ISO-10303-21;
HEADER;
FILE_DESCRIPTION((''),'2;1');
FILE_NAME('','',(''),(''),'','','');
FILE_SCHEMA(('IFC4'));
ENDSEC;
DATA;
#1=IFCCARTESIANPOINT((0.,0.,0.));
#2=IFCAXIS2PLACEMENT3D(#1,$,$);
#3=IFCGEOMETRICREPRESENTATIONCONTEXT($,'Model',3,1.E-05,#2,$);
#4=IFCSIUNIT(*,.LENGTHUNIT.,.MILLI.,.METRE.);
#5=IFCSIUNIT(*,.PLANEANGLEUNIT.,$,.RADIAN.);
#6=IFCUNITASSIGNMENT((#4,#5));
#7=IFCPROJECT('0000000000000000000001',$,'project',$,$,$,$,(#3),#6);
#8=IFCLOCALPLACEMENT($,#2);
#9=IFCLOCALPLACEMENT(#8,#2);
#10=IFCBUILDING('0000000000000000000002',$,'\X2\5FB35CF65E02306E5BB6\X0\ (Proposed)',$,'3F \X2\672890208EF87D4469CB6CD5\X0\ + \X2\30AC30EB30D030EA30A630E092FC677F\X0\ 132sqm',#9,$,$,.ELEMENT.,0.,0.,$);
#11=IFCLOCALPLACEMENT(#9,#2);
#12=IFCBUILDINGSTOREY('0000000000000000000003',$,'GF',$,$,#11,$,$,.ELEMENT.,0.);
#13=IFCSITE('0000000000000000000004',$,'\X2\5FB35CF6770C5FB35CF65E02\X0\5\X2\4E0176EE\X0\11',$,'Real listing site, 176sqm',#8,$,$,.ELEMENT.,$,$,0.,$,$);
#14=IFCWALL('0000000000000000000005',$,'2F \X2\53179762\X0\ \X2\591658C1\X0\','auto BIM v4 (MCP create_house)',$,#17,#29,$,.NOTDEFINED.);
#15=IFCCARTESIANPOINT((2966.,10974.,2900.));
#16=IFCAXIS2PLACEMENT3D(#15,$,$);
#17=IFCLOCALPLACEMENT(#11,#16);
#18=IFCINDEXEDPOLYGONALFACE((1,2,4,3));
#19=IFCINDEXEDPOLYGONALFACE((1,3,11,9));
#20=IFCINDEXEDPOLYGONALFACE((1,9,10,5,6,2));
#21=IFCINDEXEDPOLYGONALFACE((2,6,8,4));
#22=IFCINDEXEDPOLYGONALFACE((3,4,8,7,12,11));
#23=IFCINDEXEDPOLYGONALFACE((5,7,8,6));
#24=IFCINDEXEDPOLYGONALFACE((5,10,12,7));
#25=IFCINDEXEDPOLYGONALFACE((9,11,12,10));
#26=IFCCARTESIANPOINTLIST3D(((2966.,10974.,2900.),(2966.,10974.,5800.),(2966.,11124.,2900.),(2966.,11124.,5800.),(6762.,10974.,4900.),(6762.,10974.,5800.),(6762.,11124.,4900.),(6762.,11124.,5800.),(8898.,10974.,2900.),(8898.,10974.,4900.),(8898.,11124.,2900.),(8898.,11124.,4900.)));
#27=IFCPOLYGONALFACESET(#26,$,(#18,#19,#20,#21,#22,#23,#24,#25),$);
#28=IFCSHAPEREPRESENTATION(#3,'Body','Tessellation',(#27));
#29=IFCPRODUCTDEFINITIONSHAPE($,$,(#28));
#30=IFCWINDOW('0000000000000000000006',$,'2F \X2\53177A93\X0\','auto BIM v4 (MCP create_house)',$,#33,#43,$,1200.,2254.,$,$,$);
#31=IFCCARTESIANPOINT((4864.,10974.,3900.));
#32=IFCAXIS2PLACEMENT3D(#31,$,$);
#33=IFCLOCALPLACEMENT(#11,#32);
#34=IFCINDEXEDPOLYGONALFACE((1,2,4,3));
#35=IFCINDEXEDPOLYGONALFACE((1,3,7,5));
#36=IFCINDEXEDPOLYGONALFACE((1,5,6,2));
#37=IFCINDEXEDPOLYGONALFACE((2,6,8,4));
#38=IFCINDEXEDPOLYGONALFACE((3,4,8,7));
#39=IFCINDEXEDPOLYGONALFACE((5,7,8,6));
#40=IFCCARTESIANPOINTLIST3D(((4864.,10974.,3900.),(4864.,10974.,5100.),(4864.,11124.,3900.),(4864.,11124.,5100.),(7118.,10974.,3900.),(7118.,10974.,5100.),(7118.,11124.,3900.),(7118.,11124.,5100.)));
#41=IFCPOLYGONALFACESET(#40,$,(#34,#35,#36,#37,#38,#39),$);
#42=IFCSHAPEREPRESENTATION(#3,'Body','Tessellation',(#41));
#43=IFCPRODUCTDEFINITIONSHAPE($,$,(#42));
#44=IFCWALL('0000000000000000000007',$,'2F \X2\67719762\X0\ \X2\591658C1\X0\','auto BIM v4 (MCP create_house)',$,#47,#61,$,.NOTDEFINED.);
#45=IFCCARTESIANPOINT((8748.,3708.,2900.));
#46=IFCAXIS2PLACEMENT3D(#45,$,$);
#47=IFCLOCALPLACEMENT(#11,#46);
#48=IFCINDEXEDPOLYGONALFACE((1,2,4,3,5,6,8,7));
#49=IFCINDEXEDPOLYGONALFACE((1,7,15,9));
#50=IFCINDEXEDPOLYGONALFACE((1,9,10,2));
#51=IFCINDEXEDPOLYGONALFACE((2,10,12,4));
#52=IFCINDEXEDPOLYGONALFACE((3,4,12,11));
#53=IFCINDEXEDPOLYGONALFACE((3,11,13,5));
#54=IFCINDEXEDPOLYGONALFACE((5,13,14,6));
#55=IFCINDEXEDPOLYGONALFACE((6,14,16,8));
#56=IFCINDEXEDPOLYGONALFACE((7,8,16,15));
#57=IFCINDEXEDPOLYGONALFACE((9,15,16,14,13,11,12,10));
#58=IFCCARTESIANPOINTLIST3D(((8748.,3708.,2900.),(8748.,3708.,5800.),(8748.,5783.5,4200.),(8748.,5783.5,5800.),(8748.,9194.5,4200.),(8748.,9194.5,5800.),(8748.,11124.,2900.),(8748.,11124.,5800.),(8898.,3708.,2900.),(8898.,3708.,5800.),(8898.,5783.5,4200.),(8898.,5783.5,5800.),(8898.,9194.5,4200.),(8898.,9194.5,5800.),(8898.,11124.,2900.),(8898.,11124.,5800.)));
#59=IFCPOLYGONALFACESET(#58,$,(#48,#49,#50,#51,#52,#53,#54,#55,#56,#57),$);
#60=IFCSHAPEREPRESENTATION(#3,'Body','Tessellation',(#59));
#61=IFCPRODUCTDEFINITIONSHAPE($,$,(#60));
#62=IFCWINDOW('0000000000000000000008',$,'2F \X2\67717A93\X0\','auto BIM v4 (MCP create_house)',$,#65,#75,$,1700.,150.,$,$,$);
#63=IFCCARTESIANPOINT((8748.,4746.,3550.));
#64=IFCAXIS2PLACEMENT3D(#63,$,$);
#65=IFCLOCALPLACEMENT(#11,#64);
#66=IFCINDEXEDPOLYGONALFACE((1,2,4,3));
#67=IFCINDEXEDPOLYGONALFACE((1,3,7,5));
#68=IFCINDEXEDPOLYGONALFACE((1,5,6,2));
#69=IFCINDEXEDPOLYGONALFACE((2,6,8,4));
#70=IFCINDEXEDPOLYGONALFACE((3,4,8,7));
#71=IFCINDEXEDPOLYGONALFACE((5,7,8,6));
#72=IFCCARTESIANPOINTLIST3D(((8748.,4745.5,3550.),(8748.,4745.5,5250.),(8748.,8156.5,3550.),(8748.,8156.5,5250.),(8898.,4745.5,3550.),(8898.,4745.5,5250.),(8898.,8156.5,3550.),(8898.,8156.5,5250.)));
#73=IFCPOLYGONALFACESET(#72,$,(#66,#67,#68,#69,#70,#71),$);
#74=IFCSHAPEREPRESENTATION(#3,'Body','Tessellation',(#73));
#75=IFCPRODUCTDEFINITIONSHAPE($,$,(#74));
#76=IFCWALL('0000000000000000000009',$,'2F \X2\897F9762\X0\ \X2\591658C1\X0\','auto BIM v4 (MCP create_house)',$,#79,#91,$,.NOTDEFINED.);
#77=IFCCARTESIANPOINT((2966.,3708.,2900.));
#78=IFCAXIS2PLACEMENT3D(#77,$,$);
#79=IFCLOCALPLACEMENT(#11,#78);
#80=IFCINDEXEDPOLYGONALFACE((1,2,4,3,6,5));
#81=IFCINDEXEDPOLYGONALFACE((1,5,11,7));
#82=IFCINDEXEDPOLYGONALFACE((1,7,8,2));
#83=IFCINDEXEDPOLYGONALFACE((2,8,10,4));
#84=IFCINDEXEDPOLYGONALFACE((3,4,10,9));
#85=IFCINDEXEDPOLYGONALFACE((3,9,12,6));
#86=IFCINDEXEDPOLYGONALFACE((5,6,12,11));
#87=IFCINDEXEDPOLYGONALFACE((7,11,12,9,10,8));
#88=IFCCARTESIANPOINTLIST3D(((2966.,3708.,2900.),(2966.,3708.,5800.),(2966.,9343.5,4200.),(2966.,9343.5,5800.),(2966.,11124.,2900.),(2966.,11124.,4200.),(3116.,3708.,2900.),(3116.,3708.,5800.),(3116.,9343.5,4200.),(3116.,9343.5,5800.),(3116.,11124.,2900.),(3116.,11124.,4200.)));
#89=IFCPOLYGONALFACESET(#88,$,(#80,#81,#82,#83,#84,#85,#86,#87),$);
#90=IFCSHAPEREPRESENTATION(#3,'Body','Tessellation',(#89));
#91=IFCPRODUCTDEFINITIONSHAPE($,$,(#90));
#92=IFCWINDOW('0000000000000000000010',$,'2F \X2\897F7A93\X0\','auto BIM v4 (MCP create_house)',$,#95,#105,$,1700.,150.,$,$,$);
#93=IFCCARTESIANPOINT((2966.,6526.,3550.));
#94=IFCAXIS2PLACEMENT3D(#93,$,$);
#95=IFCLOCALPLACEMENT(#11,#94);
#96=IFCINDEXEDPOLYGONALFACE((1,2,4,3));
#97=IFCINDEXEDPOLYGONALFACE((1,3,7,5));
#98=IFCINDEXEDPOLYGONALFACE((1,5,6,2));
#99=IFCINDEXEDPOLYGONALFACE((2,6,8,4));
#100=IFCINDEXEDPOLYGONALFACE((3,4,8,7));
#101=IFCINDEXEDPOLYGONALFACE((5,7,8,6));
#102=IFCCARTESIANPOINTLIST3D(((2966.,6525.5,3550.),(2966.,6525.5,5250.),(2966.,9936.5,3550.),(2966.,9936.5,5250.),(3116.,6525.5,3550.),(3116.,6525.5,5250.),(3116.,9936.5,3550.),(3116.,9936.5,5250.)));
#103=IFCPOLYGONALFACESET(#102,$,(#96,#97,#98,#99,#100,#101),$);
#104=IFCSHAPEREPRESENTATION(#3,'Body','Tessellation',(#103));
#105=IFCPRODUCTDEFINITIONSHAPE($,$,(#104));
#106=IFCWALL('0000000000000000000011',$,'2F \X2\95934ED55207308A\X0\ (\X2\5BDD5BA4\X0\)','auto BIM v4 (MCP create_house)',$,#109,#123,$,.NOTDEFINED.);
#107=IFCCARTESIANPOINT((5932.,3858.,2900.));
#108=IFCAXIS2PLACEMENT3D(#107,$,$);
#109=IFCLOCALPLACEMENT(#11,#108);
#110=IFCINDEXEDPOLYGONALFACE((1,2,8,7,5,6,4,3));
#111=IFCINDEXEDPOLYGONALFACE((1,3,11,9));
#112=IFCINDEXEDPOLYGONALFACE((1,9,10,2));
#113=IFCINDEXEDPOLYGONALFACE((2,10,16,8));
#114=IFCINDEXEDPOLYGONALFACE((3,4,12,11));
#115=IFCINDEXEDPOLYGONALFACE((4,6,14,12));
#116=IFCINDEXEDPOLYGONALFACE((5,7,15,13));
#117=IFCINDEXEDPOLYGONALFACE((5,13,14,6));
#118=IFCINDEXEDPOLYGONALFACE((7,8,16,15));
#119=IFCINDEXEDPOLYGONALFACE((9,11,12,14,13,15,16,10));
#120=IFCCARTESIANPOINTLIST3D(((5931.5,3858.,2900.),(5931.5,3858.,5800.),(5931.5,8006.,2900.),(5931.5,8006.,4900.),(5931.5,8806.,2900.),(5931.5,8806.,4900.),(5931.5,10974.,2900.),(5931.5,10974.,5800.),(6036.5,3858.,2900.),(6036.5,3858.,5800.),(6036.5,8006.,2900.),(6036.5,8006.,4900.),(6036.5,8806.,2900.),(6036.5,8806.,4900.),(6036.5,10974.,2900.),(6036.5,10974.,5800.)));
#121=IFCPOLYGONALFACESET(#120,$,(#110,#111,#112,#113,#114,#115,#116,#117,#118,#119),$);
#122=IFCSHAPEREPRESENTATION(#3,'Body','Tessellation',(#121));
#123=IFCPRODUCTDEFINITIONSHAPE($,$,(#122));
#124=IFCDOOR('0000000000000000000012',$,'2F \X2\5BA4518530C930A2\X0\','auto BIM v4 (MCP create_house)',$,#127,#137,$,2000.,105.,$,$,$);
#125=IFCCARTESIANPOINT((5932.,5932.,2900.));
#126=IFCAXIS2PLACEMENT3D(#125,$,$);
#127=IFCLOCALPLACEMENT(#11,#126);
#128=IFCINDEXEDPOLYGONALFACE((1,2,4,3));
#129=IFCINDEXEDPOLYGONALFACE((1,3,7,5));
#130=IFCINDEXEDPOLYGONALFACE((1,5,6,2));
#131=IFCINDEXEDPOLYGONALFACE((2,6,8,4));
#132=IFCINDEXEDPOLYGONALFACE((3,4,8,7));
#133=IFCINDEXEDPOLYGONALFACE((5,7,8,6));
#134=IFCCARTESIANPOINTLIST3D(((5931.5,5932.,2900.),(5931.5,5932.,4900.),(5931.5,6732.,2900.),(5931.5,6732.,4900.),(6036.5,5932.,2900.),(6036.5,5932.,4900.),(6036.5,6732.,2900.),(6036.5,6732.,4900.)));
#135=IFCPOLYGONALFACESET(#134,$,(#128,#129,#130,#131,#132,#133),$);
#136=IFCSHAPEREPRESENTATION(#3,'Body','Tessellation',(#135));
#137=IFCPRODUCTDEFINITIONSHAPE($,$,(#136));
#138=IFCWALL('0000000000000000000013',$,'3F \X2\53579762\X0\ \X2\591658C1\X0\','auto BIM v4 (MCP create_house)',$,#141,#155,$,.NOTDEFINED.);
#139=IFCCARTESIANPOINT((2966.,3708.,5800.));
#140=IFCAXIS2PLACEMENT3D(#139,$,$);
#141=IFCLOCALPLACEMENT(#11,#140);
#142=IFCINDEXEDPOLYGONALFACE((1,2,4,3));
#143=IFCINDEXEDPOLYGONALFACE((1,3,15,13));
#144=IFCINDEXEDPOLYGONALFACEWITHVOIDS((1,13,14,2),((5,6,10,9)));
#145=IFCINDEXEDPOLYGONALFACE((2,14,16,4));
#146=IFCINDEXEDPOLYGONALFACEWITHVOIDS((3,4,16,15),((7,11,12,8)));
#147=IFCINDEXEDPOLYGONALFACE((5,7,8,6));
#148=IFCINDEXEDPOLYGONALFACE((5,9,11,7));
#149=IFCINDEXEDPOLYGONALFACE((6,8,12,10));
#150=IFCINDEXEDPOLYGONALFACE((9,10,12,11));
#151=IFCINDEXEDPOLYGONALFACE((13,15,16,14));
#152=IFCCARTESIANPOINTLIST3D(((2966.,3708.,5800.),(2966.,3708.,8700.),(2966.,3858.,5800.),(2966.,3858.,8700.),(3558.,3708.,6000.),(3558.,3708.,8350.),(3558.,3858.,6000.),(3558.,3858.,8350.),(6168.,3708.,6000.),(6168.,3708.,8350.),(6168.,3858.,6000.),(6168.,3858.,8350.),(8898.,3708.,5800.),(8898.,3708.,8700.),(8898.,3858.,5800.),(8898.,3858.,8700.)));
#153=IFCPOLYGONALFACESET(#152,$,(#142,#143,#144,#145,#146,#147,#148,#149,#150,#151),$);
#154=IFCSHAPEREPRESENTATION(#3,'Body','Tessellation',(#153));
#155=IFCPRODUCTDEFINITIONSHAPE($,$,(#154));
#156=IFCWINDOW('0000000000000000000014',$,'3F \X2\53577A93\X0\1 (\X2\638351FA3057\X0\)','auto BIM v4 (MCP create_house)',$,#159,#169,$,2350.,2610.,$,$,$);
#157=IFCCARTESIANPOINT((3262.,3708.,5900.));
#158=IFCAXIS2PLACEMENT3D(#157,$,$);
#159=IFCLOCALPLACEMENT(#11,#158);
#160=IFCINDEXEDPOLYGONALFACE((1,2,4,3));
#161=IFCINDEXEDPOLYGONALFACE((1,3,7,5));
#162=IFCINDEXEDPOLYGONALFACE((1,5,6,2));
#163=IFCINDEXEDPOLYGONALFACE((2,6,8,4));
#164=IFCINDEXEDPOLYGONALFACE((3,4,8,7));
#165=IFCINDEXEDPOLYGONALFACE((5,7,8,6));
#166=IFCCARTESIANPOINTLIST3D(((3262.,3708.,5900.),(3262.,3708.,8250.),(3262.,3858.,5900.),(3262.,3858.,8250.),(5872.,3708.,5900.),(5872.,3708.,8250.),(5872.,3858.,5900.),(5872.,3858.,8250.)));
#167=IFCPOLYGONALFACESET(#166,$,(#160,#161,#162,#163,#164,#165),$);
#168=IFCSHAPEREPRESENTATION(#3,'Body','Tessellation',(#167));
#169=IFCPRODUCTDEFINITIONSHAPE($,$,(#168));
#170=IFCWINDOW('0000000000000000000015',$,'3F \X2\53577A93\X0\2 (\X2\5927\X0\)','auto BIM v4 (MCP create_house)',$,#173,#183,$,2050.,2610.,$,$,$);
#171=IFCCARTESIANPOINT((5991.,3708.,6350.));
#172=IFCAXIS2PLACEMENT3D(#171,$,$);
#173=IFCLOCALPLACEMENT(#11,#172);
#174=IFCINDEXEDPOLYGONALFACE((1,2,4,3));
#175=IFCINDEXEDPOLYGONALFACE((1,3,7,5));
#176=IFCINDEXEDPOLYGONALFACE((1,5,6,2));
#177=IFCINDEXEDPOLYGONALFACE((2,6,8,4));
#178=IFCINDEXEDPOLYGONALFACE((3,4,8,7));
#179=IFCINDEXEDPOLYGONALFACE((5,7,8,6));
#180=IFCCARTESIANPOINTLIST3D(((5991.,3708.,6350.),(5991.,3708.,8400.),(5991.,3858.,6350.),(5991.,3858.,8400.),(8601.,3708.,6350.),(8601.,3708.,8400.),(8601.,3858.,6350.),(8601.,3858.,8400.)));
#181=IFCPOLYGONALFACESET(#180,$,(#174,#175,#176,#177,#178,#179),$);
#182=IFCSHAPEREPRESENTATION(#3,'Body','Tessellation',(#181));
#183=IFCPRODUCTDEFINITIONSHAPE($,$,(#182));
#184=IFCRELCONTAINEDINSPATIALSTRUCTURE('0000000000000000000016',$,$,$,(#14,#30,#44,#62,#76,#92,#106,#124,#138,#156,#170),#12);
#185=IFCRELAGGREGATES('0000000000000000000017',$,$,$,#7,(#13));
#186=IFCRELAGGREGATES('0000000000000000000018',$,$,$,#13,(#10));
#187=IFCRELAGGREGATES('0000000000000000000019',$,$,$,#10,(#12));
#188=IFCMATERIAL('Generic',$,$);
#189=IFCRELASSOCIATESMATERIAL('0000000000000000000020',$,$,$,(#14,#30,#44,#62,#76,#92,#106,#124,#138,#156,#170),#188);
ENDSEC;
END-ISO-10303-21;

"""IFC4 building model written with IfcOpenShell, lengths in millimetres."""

from ifc_helpers import new_model, si_unit, frame, frame_2d, origin, place, context, project, spatial, rectangle, extrude, material, element, fill, save


model = new_model("IFC4")

# Units and contexts
model_context = context("Model", 3, precision=1e-05, world=origin())
ifc_project = project(units=[si_unit("LENGTHUNIT", "METRE", prefix="MILLI"), si_unit("PLANEANGLEUNIT", "RADIAN")], contexts=[model_context])

# Site, building, storey
site_placement = place(None, origin())
site = spatial("IfcSite", under=ifc_project, at=site_placement, Name="徳島県徳島市5丁目11", ObjectType="Real listing site, 176sqm", CompositionType="ELEMENT", RefElevation=0.0)
building_placement = place(site_placement, origin())
building = spatial("IfcBuilding", under=site, at=building_placement, Name="徳島市の家 (Proposed)", ObjectType="3F 木造軸組構法 + ガルバリウム鋼板 132sqm", CompositionType="ELEMENT", ElevationOfRefHeight=0.0, ElevationOfTerrain=0.0)
storey_placement = place(building_placement, origin())
storey = spatial("IfcBuildingStorey", under=building, at=storey_placement, Name="GF", CompositionType="ELEMENT", Elevation=0.0)

# Shared definitions
ifc_material = material(Name="Generic")

# Walls, openings, windows
wall_1_placement = place(storey_placement, frame((2966.0, 10974.0, 2900.0)))
wall_1 = element("IfcWall", 1, at=wall_1_placement, inside=storey, material=ifc_material, Name="2F 北面 外壁", Description="auto BIM v4 (MCP create_house)", PredefinedType="NOTDEFINED", context=model_context, shape_type="SweptSolid", body=[
    extrude(rectangle(XDim=5932.0, YDim=150.0, at=frame_2d((2966.0, 75.0))), frame((2966.0, 10974.0, 2900.0)), (0.0, 0.0, 1.0), 2900.0),
])
opening_1_placement = place(storey_placement, frame((4864.0, 10974.0, 3900.0)))
opening_1 = element("IfcOpeningElement", 2, at=opening_1_placement, cuts=wall_1, PredefinedType="NOTDEFINED", context=model_context, shape_type="SweptSolid", body=[
    extrude(rectangle(XDim=2254.0, YDim=150.0, at=frame_2d((1127.0, 75.0))), frame((4864.0, 10974.0, 3900.0)), (0.0, 0.0, 1.0), 1200.0),
])
window_1_placement = place(storey_placement, frame((4864.0, 10974.0, 3900.0)))
window_1 = element("IfcWindow", 3, at=window_1_placement, inside=storey, material=ifc_material, Name="2F 北窓", Description="auto BIM v4 (MCP create_house)", OverallHeight=1200.0, OverallWidth=2254.0, context=model_context, shape_type="SweptSolid", body=[
    extrude(rectangle(XDim=2254.0, YDim=150.0, at=frame_2d((1127.0, 75.0))), frame((4864.0, 10974.0, 3900.0)), (0.0, 0.0, 1.0), 1200.0),
])
fill(opening_1, window_1)
wall_2_placement = place(storey_placement, frame((8748.0, 3708.0, 2900.0)))
wall_2 = element("IfcWall", 4, at=wall_2_placement, inside=storey, material=ifc_material, Name="2F 東面 外壁", Description="auto BIM v4 (MCP create_house)", PredefinedType="NOTDEFINED", context=model_context, shape_type="SweptSolid", body=[
    extrude(rectangle(XDim=150.0, YDim=7416.0, at=frame_2d((75.0, 3708.0))), frame((8748.0, 3708.0, 2900.0)), (0.0, 0.0, 1.0), 2900.0),
])
opening_2_placement = place(storey_placement, frame((8748.0, 4746.0, 3550.0)))
opening_2 = element("IfcOpeningElement", 5, at=opening_2_placement, cuts=wall_2, PredefinedType="NOTDEFINED", context=model_context, shape_type="SweptSolid", body=[
    extrude(rectangle(XDim=150.0, YDim=3411.0, at=frame_2d((75.0, 1705.0))), frame((8748.0, 4746.0, 3550.0)), (0.0, 0.0, 1.0), 1700.0),
])
window_2_placement = place(storey_placement, frame((8748.0, 4746.0, 3550.0)))
window_2 = element("IfcWindow", 6, at=window_2_placement, inside=storey, material=ifc_material, Name="2F 東窓", Description="auto BIM v4 (MCP create_house)", OverallHeight=1700.0, OverallWidth=150.0, context=model_context, shape_type="SweptSolid", body=[
    extrude(rectangle(XDim=150.0, YDim=3411.0, at=frame_2d((75.0, 1705.0))), frame((8748.0, 4746.0, 3550.0)), (0.0, 0.0, 1.0), 1700.0),
])
fill(opening_2, window_2)
wall_3_placement = place(storey_placement, frame((2966.0, 3708.0, 2900.0)))
wall_3 = element("IfcWall", 7, at=wall_3_placement, inside=storey, material=ifc_material, Name="2F 西面 外壁", Description="auto BIM v4 (MCP create_house)", PredefinedType="NOTDEFINED", context=model_context, shape_type="SweptSolid", body=[
    extrude(rectangle(XDim=150.0, YDim=7416.0, at=frame_2d((75.0, 3708.0))), frame((2966.0, 3708.0, 2900.0)), (0.0, 0.0, 1.0), 2900.0),
])
opening_3_placement = place(storey_placement, frame((2966.0, 6526.0, 3550.0)))
opening_3 = element("IfcOpeningElement", 8, at=opening_3_placement, cuts=wall_3, PredefinedType="NOTDEFINED", context=model_context, shape_type="SweptSolid", body=[
    extrude(rectangle(XDim=150.0, YDim=3411.0, at=frame_2d((75.0, 1705.0))), frame((2966.0, 6526.0, 3550.0)), (0.0, 0.0, 1.0), 1700.0),
])
window_3_placement = place(storey_placement, frame((2966.0, 6526.0, 3550.0)))
window_3 = element("IfcWindow", 9, at=window_3_placement, inside=storey, material=ifc_material, Name="2F 西窓", Description="auto BIM v4 (MCP create_house)", OverallHeight=1700.0, OverallWidth=150.0, context=model_context, shape_type="SweptSolid", body=[
    extrude(rectangle(XDim=150.0, YDim=3411.0, at=frame_2d((75.0, 1705.0))), frame((2966.0, 6526.0, 3550.0)), (0.0, 0.0, 1.0), 1700.0),
])
fill(opening_3, window_3)

# Wall, opening, door
wall_4_placement = place(storey_placement, frame((5932.0, 3858.0, 2900.0)))
wall_4 = element("IfcWall", 10, at=wall_4_placement, inside=storey, material=ifc_material, Name="2F 間仕切り (寝室)", Description="auto BIM v4 (MCP create_house)", PredefinedType="NOTDEFINED", context=model_context, shape_type="SweptSolid", body=[
    extrude(rectangle(XDim=105.0, YDim=7116.0, at=frame_2d((52.0, 3558.0))), frame((5932.0, 3858.0, 2900.0)), (0.0, 0.0, 1.0), 2900.0),
])
opening_4_placement = place(storey_placement, frame((5932.0, 5932.0, 2900.0)))
opening_4 = element("IfcOpeningElement", 11, at=opening_4_placement, cuts=wall_4, PredefinedType="NOTDEFINED", context=model_context, shape_type="SweptSolid", body=[
    extrude(rectangle(XDim=105.0, YDim=800.0, at=frame_2d((52.0, 400.0))), frame((5932.0, 5932.0, 2900.0)), (0.0, 0.0, 1.0), 2000.0),
])
door_1_placement = place(storey_placement, frame((5932.0, 5932.0, 2900.0)))
door_1 = element("IfcDoor", 12, at=door_1_placement, inside=storey, material=ifc_material, Name="2F 室内ドア", Description="auto BIM v4 (MCP create_house)", OverallHeight=2000.0, OverallWidth=105.0, context=model_context, shape_type="SweptSolid", body=[
    extrude(rectangle(XDim=105.0, YDim=800.0, at=frame_2d((52.0, 400.0))), frame((5932.0, 5932.0, 2900.0)), (0.0, 0.0, 1.0), 2000.0),
])
fill(opening_4, door_1)

# Wall, openings, windows
wall_5_placement = place(storey_placement, frame((2966.0, 3708.0, 5800.0)))
wall_5 = element("IfcWall", 13, at=wall_5_placement, inside=storey, material=ifc_material, Name="3F 南面 外壁", Description="auto BIM v4 (MCP create_house)", PredefinedType="NOTDEFINED", context=model_context, shape_type="SweptSolid", body=[
    extrude(rectangle(XDim=5932.0, YDim=150.0, at=frame_2d((2966.0, 75.0))), frame((2966.0, 3708.0, 5800.0)), (0.0, 0.0, 1.0), 2900.0),
])
opening_5_placement = place(storey_placement, frame((3262.0, 3708.0, 5900.0)))
opening_5 = element("IfcOpeningElement", 14, at=opening_5_placement, cuts=wall_5, PredefinedType="NOTDEFINED", context=model_context, shape_type="SweptSolid", body=[
    extrude(rectangle(XDim=2610.0, YDim=150.0, at=frame_2d((1305.0, 75.0))), frame((3262.0, 3708.0, 5900.0)), (0.0, 0.0, 1.0), 2350.0),
])
opening_6_placement = place(storey_placement, frame((5991.0, 3708.0, 6350.0)))
opening_6 = element("IfcOpeningElement", 15, at=opening_6_placement, cuts=wall_5, PredefinedType="NOTDEFINED", context=model_context, shape_type="SweptSolid", body=[
    extrude(rectangle(XDim=2610.0, YDim=150.0, at=frame_2d((1305.0, 75.0))), frame((5991.0, 3708.0, 6350.0)), (0.0, 0.0, 1.0), 2050.0),
])
window_4_placement = place(storey_placement, frame((3262.0, 3708.0, 5900.0)))
window_4 = element("IfcWindow", 16, at=window_4_placement, inside=storey, material=ifc_material, Name="3F 南窓1 (掃出し)", Description="auto BIM v4 (MCP create_house)", OverallHeight=2350.0, OverallWidth=2610.0, context=model_context, shape_type="SweptSolid", body=[
    extrude(rectangle(XDim=2610.0, YDim=150.0, at=frame_2d((1305.0, 75.0))), frame((3262.0, 3708.0, 5900.0)), (0.0, 0.0, 1.0), 2350.0),
])
fill(opening_5, window_4)
window_5_placement = place(storey_placement, frame((5991.0, 3708.0, 6350.0)))
window_5 = element("IfcWindow", 17, at=window_5_placement, inside=storey, material=ifc_material, Name="3F 南窓2 (大)", Description="auto BIM v4 (MCP create_house)", OverallHeight=2050.0, OverallWidth=2610.0, context=model_context, shape_type="SweptSolid", body=[
    extrude(rectangle(XDim=2610.0, YDim=150.0, at=frame_2d((1305.0, 75.0))), frame((5991.0, 3708.0, 6350.0)), (0.0, 0.0, 1.0), 2050.0),
])
fill(opening_6, window_5)

save(model, "model.ifc")
